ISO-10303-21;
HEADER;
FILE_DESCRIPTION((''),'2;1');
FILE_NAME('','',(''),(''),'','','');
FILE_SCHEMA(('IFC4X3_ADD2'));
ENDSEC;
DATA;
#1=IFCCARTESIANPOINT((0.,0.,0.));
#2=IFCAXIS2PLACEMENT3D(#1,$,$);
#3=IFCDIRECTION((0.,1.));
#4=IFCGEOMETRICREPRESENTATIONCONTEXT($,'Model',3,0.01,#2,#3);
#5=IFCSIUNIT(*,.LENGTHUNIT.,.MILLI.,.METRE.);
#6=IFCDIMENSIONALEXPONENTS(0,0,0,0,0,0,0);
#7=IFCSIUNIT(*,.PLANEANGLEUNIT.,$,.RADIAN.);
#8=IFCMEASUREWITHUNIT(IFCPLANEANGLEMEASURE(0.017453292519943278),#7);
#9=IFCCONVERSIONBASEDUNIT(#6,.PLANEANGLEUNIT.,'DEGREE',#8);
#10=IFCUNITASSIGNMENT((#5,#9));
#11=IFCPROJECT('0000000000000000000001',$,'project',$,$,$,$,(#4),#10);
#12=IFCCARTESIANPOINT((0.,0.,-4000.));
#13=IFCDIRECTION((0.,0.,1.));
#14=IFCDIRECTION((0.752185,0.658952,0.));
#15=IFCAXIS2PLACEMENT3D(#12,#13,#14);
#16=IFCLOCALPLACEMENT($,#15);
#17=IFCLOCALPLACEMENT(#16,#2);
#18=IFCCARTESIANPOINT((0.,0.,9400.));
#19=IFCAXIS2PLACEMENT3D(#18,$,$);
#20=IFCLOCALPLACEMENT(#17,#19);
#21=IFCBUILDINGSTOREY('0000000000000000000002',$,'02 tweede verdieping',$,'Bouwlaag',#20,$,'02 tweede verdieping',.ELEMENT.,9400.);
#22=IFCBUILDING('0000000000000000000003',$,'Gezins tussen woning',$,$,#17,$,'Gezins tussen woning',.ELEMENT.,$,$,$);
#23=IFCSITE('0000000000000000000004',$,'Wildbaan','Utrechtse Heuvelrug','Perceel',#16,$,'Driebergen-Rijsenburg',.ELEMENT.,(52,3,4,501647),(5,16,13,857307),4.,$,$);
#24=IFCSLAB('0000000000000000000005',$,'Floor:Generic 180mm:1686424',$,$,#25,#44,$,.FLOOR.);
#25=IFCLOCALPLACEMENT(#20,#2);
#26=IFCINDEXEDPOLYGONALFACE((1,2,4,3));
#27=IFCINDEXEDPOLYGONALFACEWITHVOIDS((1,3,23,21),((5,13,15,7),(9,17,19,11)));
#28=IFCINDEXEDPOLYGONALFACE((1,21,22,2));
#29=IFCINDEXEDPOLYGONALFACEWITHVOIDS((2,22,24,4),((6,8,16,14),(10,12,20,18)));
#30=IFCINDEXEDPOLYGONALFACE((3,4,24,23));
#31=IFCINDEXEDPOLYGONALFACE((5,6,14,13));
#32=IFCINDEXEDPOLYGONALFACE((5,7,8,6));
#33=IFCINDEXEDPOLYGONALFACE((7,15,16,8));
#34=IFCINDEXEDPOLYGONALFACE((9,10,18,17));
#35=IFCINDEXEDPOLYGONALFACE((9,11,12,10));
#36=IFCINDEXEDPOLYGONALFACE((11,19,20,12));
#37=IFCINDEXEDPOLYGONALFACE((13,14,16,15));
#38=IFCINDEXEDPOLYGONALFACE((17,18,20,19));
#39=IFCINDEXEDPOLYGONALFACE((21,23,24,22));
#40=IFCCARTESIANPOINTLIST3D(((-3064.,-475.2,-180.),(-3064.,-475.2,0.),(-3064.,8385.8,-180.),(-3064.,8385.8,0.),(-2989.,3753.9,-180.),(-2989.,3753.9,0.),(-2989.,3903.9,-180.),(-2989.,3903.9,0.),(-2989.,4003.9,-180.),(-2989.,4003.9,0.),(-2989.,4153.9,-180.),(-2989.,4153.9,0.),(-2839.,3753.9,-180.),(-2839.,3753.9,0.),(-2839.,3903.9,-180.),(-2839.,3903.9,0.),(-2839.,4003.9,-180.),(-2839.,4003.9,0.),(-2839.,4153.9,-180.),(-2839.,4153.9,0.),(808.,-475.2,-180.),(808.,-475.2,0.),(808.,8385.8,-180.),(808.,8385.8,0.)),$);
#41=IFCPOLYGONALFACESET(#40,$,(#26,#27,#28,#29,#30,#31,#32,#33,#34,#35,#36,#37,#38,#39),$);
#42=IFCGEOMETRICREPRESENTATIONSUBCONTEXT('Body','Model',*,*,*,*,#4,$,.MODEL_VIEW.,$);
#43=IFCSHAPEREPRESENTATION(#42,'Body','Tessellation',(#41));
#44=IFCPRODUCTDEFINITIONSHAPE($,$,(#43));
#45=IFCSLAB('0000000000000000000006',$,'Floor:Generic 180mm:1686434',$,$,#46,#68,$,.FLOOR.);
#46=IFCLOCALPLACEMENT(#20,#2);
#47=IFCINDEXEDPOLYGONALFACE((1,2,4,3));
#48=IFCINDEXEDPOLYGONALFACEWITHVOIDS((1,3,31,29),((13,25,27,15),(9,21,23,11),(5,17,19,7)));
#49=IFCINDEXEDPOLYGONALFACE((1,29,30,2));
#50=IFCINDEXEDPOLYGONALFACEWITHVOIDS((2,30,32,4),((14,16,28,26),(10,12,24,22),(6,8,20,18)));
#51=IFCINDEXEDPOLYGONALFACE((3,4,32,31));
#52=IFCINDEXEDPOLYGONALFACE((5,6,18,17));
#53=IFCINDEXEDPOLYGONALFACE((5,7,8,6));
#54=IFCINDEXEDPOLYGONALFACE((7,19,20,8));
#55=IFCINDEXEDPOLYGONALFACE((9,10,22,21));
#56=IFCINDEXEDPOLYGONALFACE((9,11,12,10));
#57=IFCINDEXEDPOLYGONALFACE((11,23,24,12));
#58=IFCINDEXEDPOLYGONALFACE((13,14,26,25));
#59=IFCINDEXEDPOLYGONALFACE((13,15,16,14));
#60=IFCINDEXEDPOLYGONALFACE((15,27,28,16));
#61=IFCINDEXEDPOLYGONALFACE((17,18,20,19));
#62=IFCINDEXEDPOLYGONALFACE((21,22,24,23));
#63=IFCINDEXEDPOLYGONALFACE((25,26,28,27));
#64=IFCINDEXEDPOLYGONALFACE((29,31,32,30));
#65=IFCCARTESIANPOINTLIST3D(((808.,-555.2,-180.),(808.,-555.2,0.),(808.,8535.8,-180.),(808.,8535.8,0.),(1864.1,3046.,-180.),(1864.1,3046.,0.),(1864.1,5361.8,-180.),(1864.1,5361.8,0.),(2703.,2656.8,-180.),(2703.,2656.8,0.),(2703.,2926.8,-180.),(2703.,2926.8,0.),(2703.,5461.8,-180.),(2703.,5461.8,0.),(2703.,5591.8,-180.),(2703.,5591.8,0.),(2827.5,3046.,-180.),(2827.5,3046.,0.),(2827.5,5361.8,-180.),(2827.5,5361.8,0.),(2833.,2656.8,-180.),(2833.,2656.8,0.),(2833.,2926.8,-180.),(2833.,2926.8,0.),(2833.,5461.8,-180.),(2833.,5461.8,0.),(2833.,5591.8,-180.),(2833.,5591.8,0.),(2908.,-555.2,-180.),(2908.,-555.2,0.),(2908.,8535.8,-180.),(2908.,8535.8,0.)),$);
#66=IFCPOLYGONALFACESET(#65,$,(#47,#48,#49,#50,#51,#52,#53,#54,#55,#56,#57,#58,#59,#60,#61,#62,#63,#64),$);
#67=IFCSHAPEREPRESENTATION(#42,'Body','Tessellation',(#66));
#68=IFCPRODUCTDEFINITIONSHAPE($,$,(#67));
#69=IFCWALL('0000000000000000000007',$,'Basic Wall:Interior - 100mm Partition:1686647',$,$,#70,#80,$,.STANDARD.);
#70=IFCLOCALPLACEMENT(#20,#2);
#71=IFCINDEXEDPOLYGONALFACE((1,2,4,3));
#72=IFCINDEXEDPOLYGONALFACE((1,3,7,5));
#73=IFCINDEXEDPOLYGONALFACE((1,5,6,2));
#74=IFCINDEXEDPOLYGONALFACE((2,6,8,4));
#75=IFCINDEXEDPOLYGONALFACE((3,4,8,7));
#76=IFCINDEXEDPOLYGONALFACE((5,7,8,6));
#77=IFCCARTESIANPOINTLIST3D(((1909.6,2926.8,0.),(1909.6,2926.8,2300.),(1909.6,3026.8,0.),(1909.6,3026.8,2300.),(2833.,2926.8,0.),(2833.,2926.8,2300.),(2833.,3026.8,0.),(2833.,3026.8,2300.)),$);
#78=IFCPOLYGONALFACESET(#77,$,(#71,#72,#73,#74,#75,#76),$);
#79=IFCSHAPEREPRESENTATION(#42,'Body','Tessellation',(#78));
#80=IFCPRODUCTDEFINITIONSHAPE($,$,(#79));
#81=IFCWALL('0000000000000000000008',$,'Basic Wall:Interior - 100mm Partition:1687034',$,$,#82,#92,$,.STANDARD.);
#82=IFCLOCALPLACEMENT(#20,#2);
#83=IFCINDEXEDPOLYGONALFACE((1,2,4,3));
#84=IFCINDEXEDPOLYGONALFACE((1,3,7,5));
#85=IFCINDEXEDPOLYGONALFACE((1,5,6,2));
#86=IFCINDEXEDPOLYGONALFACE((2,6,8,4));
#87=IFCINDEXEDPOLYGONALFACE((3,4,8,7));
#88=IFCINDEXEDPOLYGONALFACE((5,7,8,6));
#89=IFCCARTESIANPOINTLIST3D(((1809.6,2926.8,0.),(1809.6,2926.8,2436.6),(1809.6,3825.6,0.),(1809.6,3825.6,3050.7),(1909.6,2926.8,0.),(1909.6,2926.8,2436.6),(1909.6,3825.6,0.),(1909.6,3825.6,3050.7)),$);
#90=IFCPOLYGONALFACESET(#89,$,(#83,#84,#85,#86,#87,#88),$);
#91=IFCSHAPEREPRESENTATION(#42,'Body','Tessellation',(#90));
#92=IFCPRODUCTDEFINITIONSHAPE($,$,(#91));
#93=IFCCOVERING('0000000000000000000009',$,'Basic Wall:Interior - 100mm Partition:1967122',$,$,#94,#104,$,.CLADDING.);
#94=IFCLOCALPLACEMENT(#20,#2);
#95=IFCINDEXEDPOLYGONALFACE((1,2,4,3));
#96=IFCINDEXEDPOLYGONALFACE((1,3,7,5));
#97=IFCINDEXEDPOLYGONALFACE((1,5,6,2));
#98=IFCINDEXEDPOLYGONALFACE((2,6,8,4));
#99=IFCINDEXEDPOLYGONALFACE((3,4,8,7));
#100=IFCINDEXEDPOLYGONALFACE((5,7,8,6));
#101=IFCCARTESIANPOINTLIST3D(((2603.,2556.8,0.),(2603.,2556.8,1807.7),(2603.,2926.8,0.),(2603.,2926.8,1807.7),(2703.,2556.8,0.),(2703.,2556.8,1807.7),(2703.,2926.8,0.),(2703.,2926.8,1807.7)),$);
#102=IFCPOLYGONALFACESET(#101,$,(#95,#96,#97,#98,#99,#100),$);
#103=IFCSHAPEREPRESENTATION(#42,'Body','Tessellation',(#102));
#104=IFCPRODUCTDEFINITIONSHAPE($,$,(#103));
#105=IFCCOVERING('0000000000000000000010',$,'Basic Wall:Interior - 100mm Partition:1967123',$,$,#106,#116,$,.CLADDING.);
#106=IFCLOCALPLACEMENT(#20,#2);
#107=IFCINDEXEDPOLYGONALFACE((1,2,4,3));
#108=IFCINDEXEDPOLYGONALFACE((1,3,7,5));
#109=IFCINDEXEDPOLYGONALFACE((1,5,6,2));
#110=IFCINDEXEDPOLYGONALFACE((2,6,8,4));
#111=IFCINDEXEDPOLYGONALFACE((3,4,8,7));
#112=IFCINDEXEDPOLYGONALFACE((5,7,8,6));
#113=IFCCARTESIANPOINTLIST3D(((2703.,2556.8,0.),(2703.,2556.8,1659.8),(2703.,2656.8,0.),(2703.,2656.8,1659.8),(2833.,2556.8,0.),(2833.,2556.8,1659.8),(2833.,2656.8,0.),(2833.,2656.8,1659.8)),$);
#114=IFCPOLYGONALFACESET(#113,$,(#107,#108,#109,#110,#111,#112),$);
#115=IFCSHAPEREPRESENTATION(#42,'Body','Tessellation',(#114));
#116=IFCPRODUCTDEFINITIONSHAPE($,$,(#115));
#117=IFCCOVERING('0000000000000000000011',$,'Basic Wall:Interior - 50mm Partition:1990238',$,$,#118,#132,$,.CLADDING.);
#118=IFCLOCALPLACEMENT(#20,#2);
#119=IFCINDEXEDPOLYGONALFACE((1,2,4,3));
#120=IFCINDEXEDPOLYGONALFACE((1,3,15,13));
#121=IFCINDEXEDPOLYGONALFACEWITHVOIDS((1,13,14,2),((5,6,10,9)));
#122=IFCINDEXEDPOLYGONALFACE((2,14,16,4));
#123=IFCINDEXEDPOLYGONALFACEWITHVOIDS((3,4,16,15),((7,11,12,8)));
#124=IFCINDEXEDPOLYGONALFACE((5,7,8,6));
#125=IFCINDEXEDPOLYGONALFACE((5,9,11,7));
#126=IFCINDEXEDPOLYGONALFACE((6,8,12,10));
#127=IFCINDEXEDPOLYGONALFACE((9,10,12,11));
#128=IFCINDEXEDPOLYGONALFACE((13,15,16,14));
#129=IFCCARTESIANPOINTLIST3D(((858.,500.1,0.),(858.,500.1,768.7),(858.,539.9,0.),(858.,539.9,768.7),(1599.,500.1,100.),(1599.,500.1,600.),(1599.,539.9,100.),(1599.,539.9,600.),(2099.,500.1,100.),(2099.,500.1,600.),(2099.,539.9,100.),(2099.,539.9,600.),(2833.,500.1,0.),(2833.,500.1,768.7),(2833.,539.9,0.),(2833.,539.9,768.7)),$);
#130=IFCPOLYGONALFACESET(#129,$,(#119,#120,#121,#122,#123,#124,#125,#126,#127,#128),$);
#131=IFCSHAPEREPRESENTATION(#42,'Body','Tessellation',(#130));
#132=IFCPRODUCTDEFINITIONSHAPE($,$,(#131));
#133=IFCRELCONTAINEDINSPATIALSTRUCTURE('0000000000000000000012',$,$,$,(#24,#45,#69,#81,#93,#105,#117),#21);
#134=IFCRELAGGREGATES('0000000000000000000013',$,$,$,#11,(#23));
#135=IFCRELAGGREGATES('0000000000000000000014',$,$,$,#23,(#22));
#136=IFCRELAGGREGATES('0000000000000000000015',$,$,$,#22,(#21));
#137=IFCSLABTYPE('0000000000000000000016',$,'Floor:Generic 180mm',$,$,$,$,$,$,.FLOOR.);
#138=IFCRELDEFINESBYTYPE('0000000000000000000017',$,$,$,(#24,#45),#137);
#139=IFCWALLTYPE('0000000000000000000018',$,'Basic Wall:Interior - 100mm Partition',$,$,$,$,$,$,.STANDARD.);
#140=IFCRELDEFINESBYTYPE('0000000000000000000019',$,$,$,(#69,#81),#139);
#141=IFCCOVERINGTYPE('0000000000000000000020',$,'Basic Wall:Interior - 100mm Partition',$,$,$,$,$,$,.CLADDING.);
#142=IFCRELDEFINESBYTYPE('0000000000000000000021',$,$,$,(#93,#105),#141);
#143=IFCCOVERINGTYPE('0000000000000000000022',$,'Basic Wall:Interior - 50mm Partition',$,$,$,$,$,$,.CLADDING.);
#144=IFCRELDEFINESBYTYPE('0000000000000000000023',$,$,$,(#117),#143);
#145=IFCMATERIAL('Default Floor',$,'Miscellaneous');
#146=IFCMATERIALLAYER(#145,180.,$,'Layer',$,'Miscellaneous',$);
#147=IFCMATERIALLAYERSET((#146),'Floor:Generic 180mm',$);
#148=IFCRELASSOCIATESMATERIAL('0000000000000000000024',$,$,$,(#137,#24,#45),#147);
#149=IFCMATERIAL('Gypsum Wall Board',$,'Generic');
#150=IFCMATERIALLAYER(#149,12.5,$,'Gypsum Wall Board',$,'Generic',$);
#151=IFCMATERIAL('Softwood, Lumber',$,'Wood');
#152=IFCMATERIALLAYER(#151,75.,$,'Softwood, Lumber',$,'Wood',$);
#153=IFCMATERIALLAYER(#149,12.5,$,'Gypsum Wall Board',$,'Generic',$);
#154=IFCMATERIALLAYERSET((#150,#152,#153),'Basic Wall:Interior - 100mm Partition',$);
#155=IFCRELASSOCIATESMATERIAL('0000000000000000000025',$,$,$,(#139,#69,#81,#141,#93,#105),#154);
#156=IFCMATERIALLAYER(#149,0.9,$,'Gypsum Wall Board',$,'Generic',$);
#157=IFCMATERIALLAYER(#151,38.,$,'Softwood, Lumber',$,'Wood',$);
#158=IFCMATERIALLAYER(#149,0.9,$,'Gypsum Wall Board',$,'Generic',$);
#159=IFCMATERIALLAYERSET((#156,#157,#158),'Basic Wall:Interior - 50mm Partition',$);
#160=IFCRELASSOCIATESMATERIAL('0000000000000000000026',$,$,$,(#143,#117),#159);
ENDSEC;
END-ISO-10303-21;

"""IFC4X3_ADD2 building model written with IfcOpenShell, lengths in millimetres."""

from ifc_helpers import new_model, entity, si_unit, converted_unit, direction, frame, frame_2d, origin, place, context, subcontext, project, spatial, rectangle, extrude, boolean, clip, halfspace, material, layer, layer_set, layer_usage, type_object, element, save


model = new_model("IFC4X3_ADD2")

# Units and contexts
model_context = context("Model", 3, precision=0.01, world=origin(), true_north=direction((0.0, 1.0)))
body_context = subcontext(model_context, "Body", "Model", "MODEL_VIEW")
ifc_project = project(units=[si_unit("LENGTHUNIT", "METRE", prefix="MILLI"), converted_unit("PLANEANGLEUNIT", "DEGREE", entity("IfcPlaneAngleMeasure", 0.017453292519943278), si_unit("PLANEANGLEUNIT", "RADIAN"), dimensions=[0, 0, 0, 0, 0, 0, 0])], contexts=[model_context])

# Site, building, storey
site_placement = place(None, frame((0.0, 0.0, -4000.0), z_axis=(0.0, 0.0, 1.0), x_axis=(0.752185, 0.658952, 0.0)))
site = spatial("IfcSite", under=ifc_project, at=site_placement, Name="Wildbaan", Description="Utrechtse Heuvelrug", ObjectType="Perceel", LongName="Driebergen-Rijsenburg", CompositionType="ELEMENT", RefLatitude=(52, 3, 4, 501647), RefLongitude=(5, 16, 13, 857307), RefElevation=4.0)
building_placement = place(site_placement, origin())
building = spatial("IfcBuilding", under=site, at=building_placement, Name="Gezins tussen woning", LongName="Gezins tussen woning", CompositionType="ELEMENT")
storey_placement = place(building_placement, frame((0.0, 0.0, 9400.0)))
storey = spatial("IfcBuildingStorey", under=building, at=storey_placement, Name="02 tweede verdieping", ObjectType="Bouwlaag", LongName="02 tweede verdieping", CompositionType="ELEMENT", Elevation=9400.0)

# Slabs, openings
ifc_material_1 = material(Name="Default Floor", Category="Miscellaneous")
ifc_layer_1 = layer(ifc_material_1, 180.0, Name="Layer", Category="Miscellaneous")
ifc_layer_set_1 = layer_set([ifc_layer_1], Name="Floor:Generic 180mm")
ifc_layer_usage_1 = layer_usage(ifc_layer_set_1, "AXIS3", "POSITIVE", 0.0)
slab_type = type_object("IfcSlabType", Name="Floor:Generic 180mm", PredefinedType="FLOOR", material=ifc_layer_set_1)
slab_1_placement = place(storey_placement, origin())
slab_1 = element("IfcSlab", 1, at=slab_1_placement, inside=storey, type_object=slab_type, material=ifc_layer_usage_1, Name="Floor:Generic 180mm:1686424", PredefinedType="FLOOR", context=body_context, shape_type="CSG", body=[
    boolean("DIFFERENCE", boolean("DIFFERENCE", extrude(rectangle(XDim=8861.0, YDim=3872.0, at=frame_2d((0.0, 0.0), x_axis=(1.0, 0.0))), frame((-1128.0, 3955.3, 0.0), z_axis=(0.0, 0.0, -1.0), x_axis=(0.0, 1.0, 0.0)), (0.0, 0.0, 1.0), 180.0), extrude(rectangle(XDim=150.0, YDim=150.0, at=frame_2d((0.0, 0.0), x_axis=(1.0, 0.0))), frame((-2914.0, 3828.9, 0.0), z_axis=(0.0, 0.0, -1.0), x_axis=(0.0, -1.0, 0.0)), (0.0, 0.0, 1.0), 180.0)), extrude(rectangle(XDim=150.0, YDim=150.0, at=frame_2d((0.0, 0.0), x_axis=(1.0, 0.0))), frame((-2914.0, 4078.9, -180.0), z_axis=(0.0, 0.0, 1.0), x_axis=(0.0, 1.0, 0.0)), (0.0, 0.0, 1.0), 180.0)),
])
opening_1_placement = place(slab_1_placement, origin())
element("IfcOpeningElement", 2, at=opening_1_placement, cuts=slab_1, PredefinedType="OPENING", context=body_context, shape_type="SweptSolid", body=[
    extrude(rectangle(XDim=150.0, YDim=150.0, at=frame_2d((-2914.0, 4078.9), x_axis=(0.0, -1.0))), origin(), (0.0, 0.0, -1.0), 180.0),
])
opening_2_placement = place(slab_1_placement, origin())
element("IfcOpeningElement", 3, at=opening_2_placement, cuts=slab_1, PredefinedType="OPENING", context=body_context, shape_type="SweptSolid", body=[
    extrude(rectangle(XDim=150.0, YDim=150.0, at=frame_2d((-2914.0, 3828.9), x_axis=(0.0, 1.0))), origin(), (0.0, 0.0, -1.0), 180.0),
])
ifc_layer_usage_2 = layer_usage(ifc_layer_set_1, "AXIS3", "POSITIVE", 0.0)
slab_2_placement = place(storey_placement, origin())
slab_2 = element("IfcSlab", 4, at=slab_2_placement, inside=storey, type_object=slab_type, material=ifc_layer_usage_2, Name="Floor:Generic 180mm:1686434", PredefinedType="FLOOR", context=body_context, shape_type="CSG", body=[
    boolean("DIFFERENCE", boolean("DIFFERENCE", boolean("DIFFERENCE", extrude(rectangle(XDim=9091.0, YDim=2100.0, at=frame_2d((0.0, 0.0), x_axis=(1.0, 0.0))), frame((1858.0, 3990.3, 0.0), z_axis=(0.0, 0.0, -1.0), x_axis=(0.0, 1.0, 0.0)), (0.0, 0.0, 1.0), 180.0), extrude(rectangle(XDim=270.0, YDim=130.0, at=frame_2d((0.0, 0.0), x_axis=(1.0, 0.0))), frame((2768.0, 2791.8, 0.0), z_axis=(0.0, 0.0, -1.0), x_axis=(0.0, -1.0, 0.0)), (0.0, 0.0, 1.0), 180.0)), extrude(rectangle(XDim=130.0, YDim=130.0, at=frame_2d((0.0, 0.0), x_axis=(1.0, 0.0))), frame((2768.0, 5526.8, 0.0), z_axis=(0.0, 0.0, -1.0), x_axis=(0.0, -1.0, 0.0)), (0.0, 0.0, 1.0), 180.0)), extrude(rectangle(XDim=2315.8, YDim=963.4, at=frame_2d((0.0, 0.0), x_axis=(1.0, 0.0))), frame((2345.8, 4203.9, 0.0), z_axis=(0.0, 0.0, -1.0), x_axis=(0.0, -1.0, 0.0)), (0.0, 0.0, 1.0), 180.0)),
])
opening_3_placement = place(slab_2_placement, origin())
element("IfcOpeningElement", 5, at=opening_3_placement, cuts=slab_2, PredefinedType="OPENING", context=body_context, shape_type="SweptSolid", body=[
    extrude(rectangle(XDim=2315.8, YDim=963.4, at=frame_2d((2345.8, 4203.9), x_axis=(0.0, 1.0))), origin(), (0.0, 0.0, -1.0), 180.0),
])
opening_4_placement = place(slab_2_placement, origin())
element("IfcOpeningElement", 6, at=opening_4_placement, cuts=slab_2, PredefinedType="OPENING", context=body_context, shape_type="SweptSolid", body=[
    extrude(rectangle(XDim=270.0, YDim=130.0, at=frame_2d((2768.0, 2791.8), x_axis=(0.0, -1.0))), origin(), (0.0, 0.0, -1.0), 180.0),
])
opening_5_placement = place(slab_2_placement, origin())
element("IfcOpeningElement", 7, at=opening_5_placement, cuts=slab_2, PredefinedType="OPENING", context=body_context, shape_type="SweptSolid", body=[
    extrude(rectangle(XDim=130.0, YDim=130.0, at=frame_2d((2768.0, 5526.8), x_axis=(0.0, -1.0))), origin(), (0.0, 0.0, -1.0), 180.0),
])

# Shared definitions
ifc_material_2 = material(Name="Gypsum Wall Board", Category="Generic")
ifc_layer_2 = layer(ifc_material_2, 12.5, Name="Gypsum Wall Board", Category="Generic")
ifc_material_3 = material(Name="Softwood, Lumber", Category="Wood")
ifc_layer_3 = layer(ifc_material_3, 75.0, Name="Softwood, Lumber", Category="Wood")
ifc_layer_4 = layer(ifc_material_2, 12.5, Name="Gypsum Wall Board", Category="Generic")
ifc_layer_set_2 = layer_set([ifc_layer_2, ifc_layer_3, ifc_layer_4], Name="Basic Wall:Interior - 100mm Partition")
wall_type_1 = type_object("IfcWallType", Name="Basic Wall:Interior - 100mm Partition", PredefinedType="STANDARD", material=ifc_layer_set_2)

# Walls
wall_1_placement = place(storey_placement, frame((1909.6, 2976.8, 0.0)))
element("IfcWall", 8, at=wall_1_placement, inside=storey, type_object=wall_type_1, material=ifc_layer_set_2, Name="Basic Wall:Interior - 100mm Partition:1686647", PredefinedType="STANDARD", context=body_context, shape_type="SweptSolid", body=[
    extrude(rectangle(XDim=923.4, YDim=100.0, at=frame_2d((461.7, 0.0), x_axis=(-1.0, 0.0))), origin(), (0.0, 0.0, 1.0), 2300.0),
])
wall_2_placement = place(storey_placement, frame((1859.6, 3825.6, 0.0), z_axis=(0.0, 0.0, 1.0), x_axis=(0.0, -1.0, 0.0)))
element("IfcWall", 9, at=wall_2_placement, inside=storey, type_object=wall_type_1, material=ifc_layer_set_2, Name="Basic Wall:Interior - 100mm Partition:1687034", PredefinedType="STANDARD", context=body_context, shape_type="Clipping", body=[
    clip(extrude(rectangle(XDim=898.8, YDim=100.0, at=frame_2d((449.4, 0.0), x_axis=(-1.0, 0.0))), origin(), (0.0, 0.0, 1.0), 3050.7), halfspace(frame((0.0, -50.0, 3050.7), z_axis=(0.564113, 0.0, 0.825697), x_axis=(0.0, 1.0, 0.0)), False)),
])

# Coverings
ifc_layer_usage_3 = layer_usage(ifc_layer_set_2, "AXIS2", "NEGATIVE", 50.0)
covering_type_1 = type_object("IfcCoveringType", Name="Basic Wall:Interior - 100mm Partition", PredefinedType="CLADDING", material=ifc_layer_set_2)
covering_1_placement = place(storey_placement, frame((2653.0, 2926.8, 0.0), z_axis=(0.0, 0.0, 1.0), x_axis=(0.0, -1.0, 0.0)))
element("IfcCovering", 10, at=covering_1_placement, inside=storey, type_object=covering_type_1, material=ifc_layer_usage_3, Name="Basic Wall:Interior - 100mm Partition:1967122", PredefinedType="CLADDING", context=body_context, shape_type="SweptSolid", body=[
    extrude(rectangle(XDim=370.0, YDim=100.0, at=frame_2d((185.0, 0.0), x_axis=(-1.0, 0.0))), origin(), (0.0, 0.0, 1.0), 1807.7),
])
ifc_layer_usage_4 = layer_usage(ifc_layer_set_2, "AXIS2", "NEGATIVE", 50.0)
covering_2_placement = place(storey_placement, frame((2703.0, 2606.8, 0.0)))
element("IfcCovering", 11, at=covering_2_placement, inside=storey, type_object=covering_type_1, material=ifc_layer_usage_4, Name="Basic Wall:Interior - 100mm Partition:1967123", PredefinedType="CLADDING", context=body_context, shape_type="SweptSolid", body=[
    extrude(rectangle(XDim=130.0, YDim=100.0, at=frame_2d((65.0, 0.0), x_axis=(-1.0, 0.0))), origin(), (0.0, 0.0, 1.0), 1659.8),
])

# Covering, opening
ifc_layer_5 = layer(ifc_material_2, 0.9, Name="Gypsum Wall Board", Category="Generic")
ifc_layer_6 = layer(ifc_material_3, 38.0, Name="Softwood, Lumber", Category="Wood")
ifc_layer_7 = layer(ifc_material_2, 0.9, Name="Gypsum Wall Board", Category="Generic")
ifc_layer_set_3 = layer_set([ifc_layer_5, ifc_layer_6, ifc_layer_7], Name="Basic Wall:Interior - 50mm Partition")
ifc_layer_usage_5 = layer_usage(ifc_layer_set_3, "AXIS2", "NEGATIVE", 19.9)
covering_type_2 = type_object("IfcCoveringType", Name="Basic Wall:Interior - 50mm Partition", PredefinedType="CLADDING", material=ifc_layer_set_3)
covering_3_placement = place(storey_placement, frame((2833.0, 520.0, 0.0), z_axis=(0.0, 0.0, 1.0), x_axis=(-1.0, 0.0, 0.0)))
covering_3 = element("IfcCovering", 12, at=covering_3_placement, inside=storey, type_object=covering_type_2, material=ifc_layer_usage_5, Name="Basic Wall:Interior - 50mm Partition:1990238", PredefinedType="CLADDING", context=body_context, shape_type="SweptSolid", body=[
    extrude(rectangle(XDim=1975.0, YDim=39.8, at=frame_2d((987.5, 0.0), x_axis=(-1.0, 0.0))), origin(), (0.0, 0.0, 1.0), 768.7),
])
opening_6_placement = place(covering_3_placement, frame((2833.0, 520.0, 100.0), z_axis=(0.0, 0.0, 1.0), x_axis=(-1.0, 0.0, 0.0)))
element("IfcOpeningElement", 13, at=opening_6_placement, cuts=covering_3, PredefinedType="OPENING", context=body_context, shape_type="SweptSolid", body=[
    extrude(rectangle(XDim=500.0, YDim=500.0, at=frame_2d((0.0, 0.0), x_axis=(0.0, 1.0))), frame((1849.0, 539.9, 250.0), z_axis=(0.0, -1.0, 0.0), x_axis=(-1.0, 0.0, 0.0)), (0.0, 0.0, 1.0), 39.8),
])

save(model, "model.ifc")
